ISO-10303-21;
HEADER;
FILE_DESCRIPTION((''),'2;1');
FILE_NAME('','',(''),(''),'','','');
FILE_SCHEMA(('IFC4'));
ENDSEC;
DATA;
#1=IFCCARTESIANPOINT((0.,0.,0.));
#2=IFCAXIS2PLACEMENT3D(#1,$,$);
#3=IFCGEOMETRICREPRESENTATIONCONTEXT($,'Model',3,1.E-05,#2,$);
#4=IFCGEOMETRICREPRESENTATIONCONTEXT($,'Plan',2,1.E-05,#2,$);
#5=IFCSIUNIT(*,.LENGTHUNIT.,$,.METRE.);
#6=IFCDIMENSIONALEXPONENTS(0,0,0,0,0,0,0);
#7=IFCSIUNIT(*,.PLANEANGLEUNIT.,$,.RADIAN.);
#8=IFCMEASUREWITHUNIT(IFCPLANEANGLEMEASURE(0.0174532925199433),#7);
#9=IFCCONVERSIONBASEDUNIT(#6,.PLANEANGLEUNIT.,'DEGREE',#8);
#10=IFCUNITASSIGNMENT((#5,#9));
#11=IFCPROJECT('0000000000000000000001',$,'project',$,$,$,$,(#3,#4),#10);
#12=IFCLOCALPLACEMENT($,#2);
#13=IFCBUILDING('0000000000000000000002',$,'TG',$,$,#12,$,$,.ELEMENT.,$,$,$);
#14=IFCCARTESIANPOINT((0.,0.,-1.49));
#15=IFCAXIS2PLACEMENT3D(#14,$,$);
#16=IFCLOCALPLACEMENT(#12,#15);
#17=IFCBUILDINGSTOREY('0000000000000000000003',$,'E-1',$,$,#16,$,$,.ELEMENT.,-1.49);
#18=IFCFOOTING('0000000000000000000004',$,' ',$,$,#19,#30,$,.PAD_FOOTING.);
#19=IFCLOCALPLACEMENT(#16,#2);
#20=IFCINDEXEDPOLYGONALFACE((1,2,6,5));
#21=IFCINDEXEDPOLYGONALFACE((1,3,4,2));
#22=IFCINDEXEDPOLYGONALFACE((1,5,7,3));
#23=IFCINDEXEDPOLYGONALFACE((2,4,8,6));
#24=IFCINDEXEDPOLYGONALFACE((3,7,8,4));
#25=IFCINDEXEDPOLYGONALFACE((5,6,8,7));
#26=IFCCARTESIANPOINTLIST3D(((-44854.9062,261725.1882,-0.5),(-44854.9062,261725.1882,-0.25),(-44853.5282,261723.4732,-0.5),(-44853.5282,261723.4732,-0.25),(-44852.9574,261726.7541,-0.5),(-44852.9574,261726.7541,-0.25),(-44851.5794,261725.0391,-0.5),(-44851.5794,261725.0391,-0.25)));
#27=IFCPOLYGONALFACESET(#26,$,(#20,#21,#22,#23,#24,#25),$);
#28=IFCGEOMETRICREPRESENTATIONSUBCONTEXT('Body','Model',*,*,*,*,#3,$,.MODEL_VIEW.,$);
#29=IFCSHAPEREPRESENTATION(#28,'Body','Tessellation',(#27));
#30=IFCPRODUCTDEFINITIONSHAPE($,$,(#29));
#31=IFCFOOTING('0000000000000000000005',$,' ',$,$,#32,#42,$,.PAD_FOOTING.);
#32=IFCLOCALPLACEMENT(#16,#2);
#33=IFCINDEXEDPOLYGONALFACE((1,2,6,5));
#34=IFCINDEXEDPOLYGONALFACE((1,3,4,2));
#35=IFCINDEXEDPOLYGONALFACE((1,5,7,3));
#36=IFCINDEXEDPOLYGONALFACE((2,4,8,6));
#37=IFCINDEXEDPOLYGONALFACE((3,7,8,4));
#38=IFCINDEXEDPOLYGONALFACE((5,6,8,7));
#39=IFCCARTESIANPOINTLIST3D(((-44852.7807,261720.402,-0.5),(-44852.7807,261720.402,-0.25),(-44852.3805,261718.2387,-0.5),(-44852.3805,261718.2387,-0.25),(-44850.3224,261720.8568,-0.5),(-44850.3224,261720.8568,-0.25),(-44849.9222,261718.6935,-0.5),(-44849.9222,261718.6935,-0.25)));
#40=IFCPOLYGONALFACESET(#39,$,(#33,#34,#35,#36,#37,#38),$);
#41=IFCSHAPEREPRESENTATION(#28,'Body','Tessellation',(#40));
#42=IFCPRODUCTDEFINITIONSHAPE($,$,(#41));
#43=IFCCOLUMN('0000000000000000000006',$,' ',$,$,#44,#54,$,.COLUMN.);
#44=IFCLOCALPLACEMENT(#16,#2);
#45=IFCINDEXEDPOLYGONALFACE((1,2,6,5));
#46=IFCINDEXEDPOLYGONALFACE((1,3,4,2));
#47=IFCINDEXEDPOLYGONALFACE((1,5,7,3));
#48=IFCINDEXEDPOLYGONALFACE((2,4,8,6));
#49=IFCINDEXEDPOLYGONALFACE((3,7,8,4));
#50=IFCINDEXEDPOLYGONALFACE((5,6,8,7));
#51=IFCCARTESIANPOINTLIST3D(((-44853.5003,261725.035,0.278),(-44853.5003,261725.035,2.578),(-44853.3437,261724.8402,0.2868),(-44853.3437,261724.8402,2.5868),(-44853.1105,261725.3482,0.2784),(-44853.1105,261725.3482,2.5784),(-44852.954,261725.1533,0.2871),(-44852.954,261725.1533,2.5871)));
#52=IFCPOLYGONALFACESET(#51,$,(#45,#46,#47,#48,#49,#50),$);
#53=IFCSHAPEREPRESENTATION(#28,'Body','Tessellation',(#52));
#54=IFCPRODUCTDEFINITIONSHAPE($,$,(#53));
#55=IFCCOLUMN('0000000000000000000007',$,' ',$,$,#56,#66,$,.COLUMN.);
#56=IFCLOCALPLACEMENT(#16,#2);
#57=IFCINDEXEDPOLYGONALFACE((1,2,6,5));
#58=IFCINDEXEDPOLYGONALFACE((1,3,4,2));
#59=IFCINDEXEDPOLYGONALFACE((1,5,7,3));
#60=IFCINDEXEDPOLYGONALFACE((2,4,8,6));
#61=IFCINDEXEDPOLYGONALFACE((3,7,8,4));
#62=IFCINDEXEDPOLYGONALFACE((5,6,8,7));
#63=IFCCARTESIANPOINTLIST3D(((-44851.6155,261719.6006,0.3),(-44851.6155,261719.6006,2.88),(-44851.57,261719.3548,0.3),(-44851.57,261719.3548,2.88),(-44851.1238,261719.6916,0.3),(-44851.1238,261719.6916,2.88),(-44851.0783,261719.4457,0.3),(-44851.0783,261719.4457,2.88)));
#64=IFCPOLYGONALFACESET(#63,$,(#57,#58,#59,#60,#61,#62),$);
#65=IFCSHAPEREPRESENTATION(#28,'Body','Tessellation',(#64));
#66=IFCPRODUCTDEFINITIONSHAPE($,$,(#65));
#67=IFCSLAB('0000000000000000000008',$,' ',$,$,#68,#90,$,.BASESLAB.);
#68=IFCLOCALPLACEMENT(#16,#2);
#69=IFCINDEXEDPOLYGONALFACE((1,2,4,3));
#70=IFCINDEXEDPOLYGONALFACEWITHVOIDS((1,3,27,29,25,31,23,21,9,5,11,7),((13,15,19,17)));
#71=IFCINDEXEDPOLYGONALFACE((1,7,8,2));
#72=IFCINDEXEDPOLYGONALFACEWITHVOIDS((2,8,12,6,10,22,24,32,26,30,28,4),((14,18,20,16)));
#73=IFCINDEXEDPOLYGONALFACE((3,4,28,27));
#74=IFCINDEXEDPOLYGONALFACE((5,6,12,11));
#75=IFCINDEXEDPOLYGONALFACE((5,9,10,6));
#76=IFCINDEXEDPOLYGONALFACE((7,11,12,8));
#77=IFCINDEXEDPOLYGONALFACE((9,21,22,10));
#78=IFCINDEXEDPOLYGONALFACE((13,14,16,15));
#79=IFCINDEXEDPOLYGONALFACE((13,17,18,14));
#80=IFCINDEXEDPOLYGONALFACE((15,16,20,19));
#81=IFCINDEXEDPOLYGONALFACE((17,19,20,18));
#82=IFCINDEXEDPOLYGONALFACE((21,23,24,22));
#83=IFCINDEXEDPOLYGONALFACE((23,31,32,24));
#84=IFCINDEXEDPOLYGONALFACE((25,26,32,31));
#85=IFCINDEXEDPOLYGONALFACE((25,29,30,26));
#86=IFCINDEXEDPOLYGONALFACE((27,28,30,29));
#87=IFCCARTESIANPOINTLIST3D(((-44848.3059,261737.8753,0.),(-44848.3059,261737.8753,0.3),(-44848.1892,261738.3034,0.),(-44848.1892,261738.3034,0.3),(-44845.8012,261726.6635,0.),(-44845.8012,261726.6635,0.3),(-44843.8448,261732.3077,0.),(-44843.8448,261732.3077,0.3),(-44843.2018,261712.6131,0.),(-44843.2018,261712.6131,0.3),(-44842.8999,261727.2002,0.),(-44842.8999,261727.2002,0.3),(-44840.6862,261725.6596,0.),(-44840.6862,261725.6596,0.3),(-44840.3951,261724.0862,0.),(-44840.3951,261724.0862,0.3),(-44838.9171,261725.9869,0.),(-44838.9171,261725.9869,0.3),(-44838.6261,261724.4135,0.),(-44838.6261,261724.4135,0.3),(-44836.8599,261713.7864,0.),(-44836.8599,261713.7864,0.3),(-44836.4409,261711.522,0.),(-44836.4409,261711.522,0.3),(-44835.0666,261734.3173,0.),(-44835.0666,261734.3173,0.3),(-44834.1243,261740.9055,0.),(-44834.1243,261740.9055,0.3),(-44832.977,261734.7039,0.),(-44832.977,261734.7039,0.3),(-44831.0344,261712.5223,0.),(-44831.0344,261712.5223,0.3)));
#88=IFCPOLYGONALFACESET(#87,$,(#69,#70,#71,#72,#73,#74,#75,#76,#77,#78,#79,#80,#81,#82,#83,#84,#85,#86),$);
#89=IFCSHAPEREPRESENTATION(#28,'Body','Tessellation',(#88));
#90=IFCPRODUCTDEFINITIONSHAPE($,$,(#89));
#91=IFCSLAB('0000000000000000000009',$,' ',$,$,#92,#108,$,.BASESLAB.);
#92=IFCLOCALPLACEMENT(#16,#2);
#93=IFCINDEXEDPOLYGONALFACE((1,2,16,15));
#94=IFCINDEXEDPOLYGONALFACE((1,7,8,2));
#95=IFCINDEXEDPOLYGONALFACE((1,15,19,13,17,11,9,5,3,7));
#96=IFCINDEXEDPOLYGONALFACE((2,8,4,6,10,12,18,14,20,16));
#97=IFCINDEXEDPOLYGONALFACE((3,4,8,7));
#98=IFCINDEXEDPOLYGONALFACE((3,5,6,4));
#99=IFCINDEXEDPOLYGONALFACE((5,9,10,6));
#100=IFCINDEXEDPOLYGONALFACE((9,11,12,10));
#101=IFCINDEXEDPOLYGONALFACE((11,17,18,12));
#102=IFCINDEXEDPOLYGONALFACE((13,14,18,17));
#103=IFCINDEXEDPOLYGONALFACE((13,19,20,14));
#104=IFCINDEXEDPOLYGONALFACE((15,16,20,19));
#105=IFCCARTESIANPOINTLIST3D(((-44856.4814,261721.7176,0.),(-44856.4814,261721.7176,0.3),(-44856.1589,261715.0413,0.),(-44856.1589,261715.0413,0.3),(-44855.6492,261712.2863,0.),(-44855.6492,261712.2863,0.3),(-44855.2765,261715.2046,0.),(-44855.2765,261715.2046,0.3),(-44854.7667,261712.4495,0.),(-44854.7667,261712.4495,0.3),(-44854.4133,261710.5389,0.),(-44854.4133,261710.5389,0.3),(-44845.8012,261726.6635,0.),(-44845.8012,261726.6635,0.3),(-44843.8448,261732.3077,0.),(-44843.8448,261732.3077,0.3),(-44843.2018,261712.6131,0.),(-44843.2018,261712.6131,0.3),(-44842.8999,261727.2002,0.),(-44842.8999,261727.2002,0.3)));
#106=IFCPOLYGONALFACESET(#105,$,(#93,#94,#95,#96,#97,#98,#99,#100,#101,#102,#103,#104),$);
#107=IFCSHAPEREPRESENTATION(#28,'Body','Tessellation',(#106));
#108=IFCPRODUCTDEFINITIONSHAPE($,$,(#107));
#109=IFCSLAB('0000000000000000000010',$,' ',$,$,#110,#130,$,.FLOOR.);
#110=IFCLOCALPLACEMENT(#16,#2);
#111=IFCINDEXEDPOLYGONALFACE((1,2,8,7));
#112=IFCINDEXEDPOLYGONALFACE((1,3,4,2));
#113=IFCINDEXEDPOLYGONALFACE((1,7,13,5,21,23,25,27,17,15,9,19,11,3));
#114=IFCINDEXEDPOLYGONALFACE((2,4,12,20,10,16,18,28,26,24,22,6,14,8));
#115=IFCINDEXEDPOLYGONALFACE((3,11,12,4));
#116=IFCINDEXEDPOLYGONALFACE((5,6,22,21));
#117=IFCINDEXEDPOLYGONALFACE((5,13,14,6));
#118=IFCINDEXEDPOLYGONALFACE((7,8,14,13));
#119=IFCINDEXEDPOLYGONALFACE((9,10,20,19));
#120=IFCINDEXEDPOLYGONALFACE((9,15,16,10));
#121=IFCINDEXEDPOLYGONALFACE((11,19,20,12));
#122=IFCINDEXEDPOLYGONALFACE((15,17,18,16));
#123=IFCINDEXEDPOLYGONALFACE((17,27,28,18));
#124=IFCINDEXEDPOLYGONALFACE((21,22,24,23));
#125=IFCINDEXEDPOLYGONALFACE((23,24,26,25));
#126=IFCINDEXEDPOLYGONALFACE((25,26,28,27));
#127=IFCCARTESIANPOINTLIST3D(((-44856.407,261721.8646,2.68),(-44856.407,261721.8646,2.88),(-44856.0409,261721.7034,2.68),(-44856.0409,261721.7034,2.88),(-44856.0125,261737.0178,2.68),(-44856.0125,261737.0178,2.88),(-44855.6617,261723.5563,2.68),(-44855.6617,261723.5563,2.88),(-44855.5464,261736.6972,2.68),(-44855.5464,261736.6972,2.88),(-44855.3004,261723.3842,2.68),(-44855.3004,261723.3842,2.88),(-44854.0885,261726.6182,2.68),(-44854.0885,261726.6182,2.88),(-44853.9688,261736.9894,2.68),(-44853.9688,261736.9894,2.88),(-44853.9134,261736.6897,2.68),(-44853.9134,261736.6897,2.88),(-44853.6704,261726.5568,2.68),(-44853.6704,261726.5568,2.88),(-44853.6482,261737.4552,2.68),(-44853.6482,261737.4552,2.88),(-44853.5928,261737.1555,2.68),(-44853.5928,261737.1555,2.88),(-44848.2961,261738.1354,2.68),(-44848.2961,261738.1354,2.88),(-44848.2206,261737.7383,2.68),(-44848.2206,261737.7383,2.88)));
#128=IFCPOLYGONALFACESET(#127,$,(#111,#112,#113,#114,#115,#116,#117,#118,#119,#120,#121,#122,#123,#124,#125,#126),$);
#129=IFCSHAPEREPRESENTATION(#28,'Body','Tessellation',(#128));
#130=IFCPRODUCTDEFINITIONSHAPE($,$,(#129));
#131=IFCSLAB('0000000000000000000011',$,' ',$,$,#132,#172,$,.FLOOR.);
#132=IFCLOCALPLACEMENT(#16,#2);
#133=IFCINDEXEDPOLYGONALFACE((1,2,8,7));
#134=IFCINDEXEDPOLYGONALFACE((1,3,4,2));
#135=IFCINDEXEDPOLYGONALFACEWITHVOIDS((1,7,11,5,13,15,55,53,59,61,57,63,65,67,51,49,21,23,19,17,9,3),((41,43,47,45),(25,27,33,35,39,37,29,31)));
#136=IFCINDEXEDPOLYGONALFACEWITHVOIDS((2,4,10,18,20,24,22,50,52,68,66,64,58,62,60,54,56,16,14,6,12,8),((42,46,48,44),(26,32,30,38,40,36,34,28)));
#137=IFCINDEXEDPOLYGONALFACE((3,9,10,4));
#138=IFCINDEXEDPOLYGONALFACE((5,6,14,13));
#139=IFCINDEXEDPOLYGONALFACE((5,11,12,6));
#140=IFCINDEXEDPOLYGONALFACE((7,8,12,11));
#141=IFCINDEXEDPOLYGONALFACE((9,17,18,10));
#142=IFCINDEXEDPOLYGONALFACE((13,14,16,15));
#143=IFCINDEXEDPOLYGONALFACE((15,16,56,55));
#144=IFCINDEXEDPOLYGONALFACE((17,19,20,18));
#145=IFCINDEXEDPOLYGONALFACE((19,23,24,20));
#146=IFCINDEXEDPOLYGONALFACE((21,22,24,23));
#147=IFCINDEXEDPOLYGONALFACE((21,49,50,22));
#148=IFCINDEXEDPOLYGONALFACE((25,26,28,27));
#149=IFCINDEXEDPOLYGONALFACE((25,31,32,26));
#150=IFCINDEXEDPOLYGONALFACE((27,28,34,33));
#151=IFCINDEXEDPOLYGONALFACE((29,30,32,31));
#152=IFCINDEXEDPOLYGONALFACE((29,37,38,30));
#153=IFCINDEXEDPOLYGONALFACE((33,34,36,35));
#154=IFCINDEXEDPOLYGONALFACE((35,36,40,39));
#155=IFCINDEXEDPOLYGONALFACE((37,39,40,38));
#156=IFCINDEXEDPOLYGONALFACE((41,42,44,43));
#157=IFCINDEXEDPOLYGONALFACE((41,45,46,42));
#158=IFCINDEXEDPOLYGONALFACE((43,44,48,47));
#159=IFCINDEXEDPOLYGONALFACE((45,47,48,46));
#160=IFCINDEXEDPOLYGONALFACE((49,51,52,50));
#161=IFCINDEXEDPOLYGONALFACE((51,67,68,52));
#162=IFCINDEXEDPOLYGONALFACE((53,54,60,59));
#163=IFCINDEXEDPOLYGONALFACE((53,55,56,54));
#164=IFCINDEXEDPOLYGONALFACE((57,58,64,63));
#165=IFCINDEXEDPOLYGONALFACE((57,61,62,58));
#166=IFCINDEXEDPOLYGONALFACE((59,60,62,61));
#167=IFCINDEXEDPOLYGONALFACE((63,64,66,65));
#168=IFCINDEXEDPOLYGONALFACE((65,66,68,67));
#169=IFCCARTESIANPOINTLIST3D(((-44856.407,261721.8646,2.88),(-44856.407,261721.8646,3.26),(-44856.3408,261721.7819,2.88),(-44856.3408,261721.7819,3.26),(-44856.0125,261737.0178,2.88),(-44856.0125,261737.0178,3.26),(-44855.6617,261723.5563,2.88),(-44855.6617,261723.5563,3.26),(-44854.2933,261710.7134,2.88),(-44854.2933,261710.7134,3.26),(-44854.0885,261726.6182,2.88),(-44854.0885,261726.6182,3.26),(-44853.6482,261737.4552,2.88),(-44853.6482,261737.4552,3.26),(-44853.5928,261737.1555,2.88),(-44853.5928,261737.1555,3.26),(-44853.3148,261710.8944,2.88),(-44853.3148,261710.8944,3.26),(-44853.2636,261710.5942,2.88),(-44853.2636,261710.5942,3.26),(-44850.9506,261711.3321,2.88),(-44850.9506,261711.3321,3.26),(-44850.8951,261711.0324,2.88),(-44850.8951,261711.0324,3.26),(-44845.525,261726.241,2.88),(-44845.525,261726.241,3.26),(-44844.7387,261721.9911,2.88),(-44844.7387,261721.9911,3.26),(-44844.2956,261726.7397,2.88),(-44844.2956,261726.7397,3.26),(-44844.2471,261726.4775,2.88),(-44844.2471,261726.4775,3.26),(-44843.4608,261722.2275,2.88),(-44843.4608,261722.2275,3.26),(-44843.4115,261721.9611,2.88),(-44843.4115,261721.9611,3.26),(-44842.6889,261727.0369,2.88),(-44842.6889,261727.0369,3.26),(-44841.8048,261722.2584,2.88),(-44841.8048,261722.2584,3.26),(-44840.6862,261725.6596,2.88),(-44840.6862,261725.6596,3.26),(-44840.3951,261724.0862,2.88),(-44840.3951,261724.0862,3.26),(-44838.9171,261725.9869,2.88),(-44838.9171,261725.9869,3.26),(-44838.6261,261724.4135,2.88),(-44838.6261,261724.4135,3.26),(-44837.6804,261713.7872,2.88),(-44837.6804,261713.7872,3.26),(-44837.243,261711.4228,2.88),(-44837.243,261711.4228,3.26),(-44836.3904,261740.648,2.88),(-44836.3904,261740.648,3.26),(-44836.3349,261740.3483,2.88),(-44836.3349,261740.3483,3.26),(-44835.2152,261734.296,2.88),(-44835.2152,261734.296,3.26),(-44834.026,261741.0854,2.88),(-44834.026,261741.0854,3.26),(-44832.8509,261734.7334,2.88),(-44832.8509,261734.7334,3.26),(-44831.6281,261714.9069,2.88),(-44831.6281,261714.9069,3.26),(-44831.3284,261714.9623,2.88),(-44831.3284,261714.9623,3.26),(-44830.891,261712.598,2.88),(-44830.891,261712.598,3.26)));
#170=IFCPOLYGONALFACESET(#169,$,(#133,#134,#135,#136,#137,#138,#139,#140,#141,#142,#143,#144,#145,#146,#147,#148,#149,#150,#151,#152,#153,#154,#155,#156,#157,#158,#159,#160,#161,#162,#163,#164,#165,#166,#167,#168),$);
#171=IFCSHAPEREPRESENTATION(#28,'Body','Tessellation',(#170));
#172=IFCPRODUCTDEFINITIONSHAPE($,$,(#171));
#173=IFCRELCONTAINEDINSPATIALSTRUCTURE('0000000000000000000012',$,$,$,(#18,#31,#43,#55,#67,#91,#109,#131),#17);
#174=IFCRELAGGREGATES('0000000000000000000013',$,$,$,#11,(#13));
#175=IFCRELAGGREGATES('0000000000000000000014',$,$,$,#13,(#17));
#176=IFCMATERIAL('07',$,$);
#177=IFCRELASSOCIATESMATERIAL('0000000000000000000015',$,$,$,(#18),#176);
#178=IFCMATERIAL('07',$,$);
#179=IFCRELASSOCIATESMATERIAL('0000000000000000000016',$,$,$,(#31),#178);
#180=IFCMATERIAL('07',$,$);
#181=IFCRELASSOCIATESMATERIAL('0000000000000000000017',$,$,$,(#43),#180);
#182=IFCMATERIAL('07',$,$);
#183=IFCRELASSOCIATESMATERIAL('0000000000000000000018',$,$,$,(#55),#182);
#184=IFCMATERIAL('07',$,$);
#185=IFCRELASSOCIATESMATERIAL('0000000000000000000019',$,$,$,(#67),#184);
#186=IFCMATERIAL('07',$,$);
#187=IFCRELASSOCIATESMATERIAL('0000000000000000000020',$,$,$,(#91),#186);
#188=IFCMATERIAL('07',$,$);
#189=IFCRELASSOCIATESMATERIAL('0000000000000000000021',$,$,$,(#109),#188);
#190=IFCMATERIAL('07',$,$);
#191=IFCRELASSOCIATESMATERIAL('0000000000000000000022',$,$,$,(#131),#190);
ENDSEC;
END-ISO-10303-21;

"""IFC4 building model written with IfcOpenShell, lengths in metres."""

from ifc_helpers import new_model, entity, si_unit, converted_unit, frame, frame_2d, origin, origin_with_axes, place, context, subcontext, project, spatial, polyline, rectangle, outline, extrude, clip, halfspace, material, element, save


model = new_model("IFC4")

# Units and contexts
model_context = context("Model", 3, precision=1e-05, world=origin())
plan_context = context("Plan", 2, precision=1e-05, world=origin())
body_context = subcontext(model_context, "Body", "Model", "MODEL_VIEW")
ifc_project = project(units=[si_unit("LENGTHUNIT", "METRE"), converted_unit("PLANEANGLEUNIT", "DEGREE", entity("IfcPlaneAngleMeasure", 0.0174532925199433), si_unit("PLANEANGLEUNIT", "RADIAN"), dimensions=[0, 0, 0, 0, 0, 0, 0])], contexts=[model_context, plan_context])

# Building, storey
building_placement = place(None, origin())
building = spatial("IfcBuilding", under=ifc_project, at=building_placement, Name="TG", CompositionType="ELEMENT")
storey_placement = place(building_placement, frame((0.0, 0.0, -1.49)))
storey = spatial("IfcBuildingStorey", under=building, at=storey_placement, Name="E-1", CompositionType="ELEMENT", Elevation=-1.49)

# Footings
ifc_material_1 = material(Name="07")
footing_1_placement = place(storey_placement, frame((-44854.9062, 261723.4732, -0.5)))
element("IfcFooting", 1, at=footing_1_placement, inside=storey, material=ifc_material_1, Name=" ", PredefinedType="PAD_FOOTING", context=body_context, shape_type="SweptSolid", body=[
    extrude(rectangle(XDim=2.5, YDim=2.2, at=frame_2d((0.2854, 1.6404), x_axis=(0.779531, 0.626364))), frame((1.378, 0.0, 0.0), z_axis=(0.0, 0.0, 1.0), x_axis=(1.0, 0.0, 0.0)), (0.0, 0.0, 1.0), 0.25),
])
ifc_material_2 = material(Name="07")
footing_2_placement = place(storey_placement, frame((-44852.7807, 261718.2387, -0.5)))
element("IfcFooting", 2, at=footing_2_placement, inside=storey, material=ifc_material_2, Name=" ", PredefinedType="PAD_FOOTING", context=body_context, shape_type="SweptSolid", body=[
    extrude(rectangle(XDim=2.5, YDim=2.2, at=frame_2d((-1.029, -1.309), x_axis=(-0.983313, -0.18192))), frame((2.4583, 2.6181, 0.0), z_axis=(0.0, 0.0, 1.0), x_axis=(1.0, 0.0, 0.0)), (0.0, 0.0, 1.0), 0.25),
])

# Columns
ifc_material_3 = material(Name="07")
column_1_placement = place(storey_placement, frame((-44853.1105, 261725.3482, 0.278)))
element("IfcColumn", 3, at=column_1_placement, inside=storey, material=ifc_material_3, Name=" ", PredefinedType="COLUMN", context=body_context, shape_type="Clipping", body=[
    clip(clip(extrude(rectangle(XDim=0.5, YDim=0.25, at=frame_2d((-0.1166, -0.254), x_axis=(-0.779531, -0.626364))), origin_with_axes(), (0.0, 0.0, 1.0), 2.3091), halfspace(frame((-0.1166, -0.254, 0.0046), z_axis=(-0.022501, 0.026849, 0.999386), x_axis=(-0.62598, 0.779053, -0.035023)), True)), halfspace(frame((-0.1166, -0.254, 2.3046), z_axis=(0.022501, -0.026849, -0.999386), x_axis=(-0.779531, -0.626364, -0.000723)), True)),
])
ifc_material_4 = material(Name="07")
column_2_placement = place(storey_placement, frame((-44851.1238, 261719.6916, 0.3)))
element("IfcColumn", 4, at=column_2_placement, inside=storey, material=ifc_material_4, Name=" ", PredefinedType="COLUMN", context=body_context, shape_type="SweptSolid", body=[
    extrude(rectangle(XDim=0.5, YDim=0.25, at=frame_2d((-0.2231, -0.1684), x_axis=(-0.983313, -0.18192))), origin_with_axes(), (0.0, 0.0, 1.0), 2.58),
])

# Slab, opening
ifc_material_5 = material(Name="07")
slab_1_placement = place(storey_placement, frame((-44848.3059, 261711.522, 0.0)))
slab_1 = element("IfcSlab", 5, at=slab_1_placement, inside=storey, material=ifc_material_5, Name=" ", PredefinedType="BASESLAB", context=body_context, shape_type="SweptSolid", body=[
    extrude(outline(polyline([(0.0, 26.3533), (4.4611, 20.7857), (5.406, 15.6782), (2.5048, 15.1415), (5.1042, 1.0911), (11.4461, 2.2644), (11.865, 0.0), (17.2716, 1.0003), (13.2393, 22.7953), (15.3289, 23.1819), (14.1816, 29.3835), (0.1167, 26.7814), (0.0, 26.3533)])), origin_with_axes(), (0.0, 0.0, 1.0), 0.3),
])
opening_1_placement = place(slab_1_placement, frame((7.6197, 12.5642, 0.0)))
element("IfcOpeningStandardCase", 6, at=opening_1_placement, cuts=slab_1, PredefinedType="OPENING", context=body_context, shape_type="SweptSolid", body=[
    extrude(rectangle(XDim=1.7991, YDim=1.6001, at=frame_2d((0.0, 0.0), x_axis=(-0.983313, -0.18192))), frame((1.0301, 0.9504, 0.0), z_axis=(0.0, 0.0, 1.0), x_axis=(1.0, 0.0, 0.0)), (0.0, 0.0, 1.0), 0.3),
])

# Slabs
ifc_material_6 = material(Name="07")
slab_2_placement = place(storey_placement, frame((-44856.4814, 261710.5389, 0.0)))
element("IfcSlab", 7, at=slab_2_placement, inside=storey, material=ifc_material_6, Name=" ", PredefinedType="BASESLAB", context=body_context, shape_type="SweptSolid", body=[
    extrude(outline(polyline([(12.6366, 21.7687), (0.0, 11.1786), (1.2049, 4.6657), (0.3225, 4.5024), (0.8322, 1.7473), (1.7146, 1.9106), (2.0681, 0.0), (13.2796, 2.0742), (10.6802, 16.1246), (13.5815, 16.6613), (12.6366, 21.7687)])), origin_with_axes(), (0.0, 0.0, 1.0), 0.3),
])
ifc_material_7 = material(Name="07")
slab_3_placement = place(storey_placement, frame((-44856.407, 261721.7034, 2.68)))
element("IfcSlab", 8, at=slab_3_placement, inside=storey, material=ifc_material_7, Name=" ", PredefinedType="FLOOR", context=body_context, shape_type="SweptSolid", body=[
    extrude(outline(polyline([(0.0, 0.1613), (0.366, 0.0), (1.1065, 1.6808), (2.7366, 4.8534), (0.8605, 14.9938), (2.4381, 15.286), (2.4936, 14.9863), (8.1863, 16.0349), (8.1109, 16.432), (2.8142, 15.4521), (2.7588, 15.7518), (0.3944, 15.3144), (2.3184, 4.9149), (0.7453, 1.853), (0.0, 0.1613)])), origin_with_axes(), (0.0, 0.0, 1.0), 0.2),
])

# Slab, openings
ifc_material_8 = material(Name="07")
slab_4_placement = place(storey_placement, frame((-44856.407, 261710.5942, 2.88)))
slab_4 = element("IfcSlab", 9, at=slab_4_placement, inside=storey, material=ifc_material_8, Name=" ", PredefinedType="FLOOR", context=body_context, shape_type="SweptSolid", body=[
    extrude(outline(polyline([(0.3944, 26.4235), (2.3184, 16.024), (0.7453, 12.9621), (0.0, 11.2704), (0.0662, 11.1877), (2.1137, 0.1192), (3.0922, 0.3002), (3.1434, 0.0), (5.5119, 0.4382), (5.4564, 0.7379), (18.7266, 3.193), (19.164, 0.8286), (25.516, 2.0038), (25.0786, 4.3681), (24.7789, 4.3127), (21.1918, 23.7018), (23.5561, 24.1392), (22.3809, 30.4912), (20.0166, 30.0538), (20.0721, 29.7541), (2.8142, 26.5613), (2.7588, 26.861), (0.3944, 26.4235)])), origin_with_axes(), (0.0, 0.0, 1.0), 0.38),
])
opening_2_placement = place(slab_4_placement, frame((10.882, 11.3669, 0.0)))
element("IfcOpeningStandardCase", 10, at=opening_2_placement, cuts=slab_4, PredefinedType="OPENING", context=body_context, shape_type="SweptSolid", body=[
    extrude(outline(polyline([(-0.4755, 2.1108), (-1.7534, 1.8744), (-0.9672, -2.3756), (0.3107, -2.1391), (0.36, -2.4055), (1.9668, -2.1083), (1.0827, 2.6703), (-0.5241, 2.373), (-0.4755, 2.1108)])), frame((1.7534, 2.4055, 0.0), z_axis=(0.0, 0.0, 1.0), x_axis=(1.0, 0.0, 0.0)), (0.0, 0.0, 1.0), 0.38),
])
opening_3_placement = place(slab_4_placement, frame((15.7208, 13.492, 0.0)))
element("IfcOpeningStandardCase", 11, at=opening_3_placement, cuts=slab_4, PredefinedType="OPENING", context=body_context, shape_type="SweptSolid", body=[
    extrude(rectangle(XDim=1.7991, YDim=1.6001, at=frame_2d((0.0, 0.0), x_axis=(-0.983313, -0.18192))), frame((1.0301, 0.9504, 0.0), z_axis=(0.0, 0.0, 1.0), x_axis=(1.0, 0.0, 0.0)), (0.0, 0.0, 1.0), 0.38),
])

save(model, "model.ifc")
